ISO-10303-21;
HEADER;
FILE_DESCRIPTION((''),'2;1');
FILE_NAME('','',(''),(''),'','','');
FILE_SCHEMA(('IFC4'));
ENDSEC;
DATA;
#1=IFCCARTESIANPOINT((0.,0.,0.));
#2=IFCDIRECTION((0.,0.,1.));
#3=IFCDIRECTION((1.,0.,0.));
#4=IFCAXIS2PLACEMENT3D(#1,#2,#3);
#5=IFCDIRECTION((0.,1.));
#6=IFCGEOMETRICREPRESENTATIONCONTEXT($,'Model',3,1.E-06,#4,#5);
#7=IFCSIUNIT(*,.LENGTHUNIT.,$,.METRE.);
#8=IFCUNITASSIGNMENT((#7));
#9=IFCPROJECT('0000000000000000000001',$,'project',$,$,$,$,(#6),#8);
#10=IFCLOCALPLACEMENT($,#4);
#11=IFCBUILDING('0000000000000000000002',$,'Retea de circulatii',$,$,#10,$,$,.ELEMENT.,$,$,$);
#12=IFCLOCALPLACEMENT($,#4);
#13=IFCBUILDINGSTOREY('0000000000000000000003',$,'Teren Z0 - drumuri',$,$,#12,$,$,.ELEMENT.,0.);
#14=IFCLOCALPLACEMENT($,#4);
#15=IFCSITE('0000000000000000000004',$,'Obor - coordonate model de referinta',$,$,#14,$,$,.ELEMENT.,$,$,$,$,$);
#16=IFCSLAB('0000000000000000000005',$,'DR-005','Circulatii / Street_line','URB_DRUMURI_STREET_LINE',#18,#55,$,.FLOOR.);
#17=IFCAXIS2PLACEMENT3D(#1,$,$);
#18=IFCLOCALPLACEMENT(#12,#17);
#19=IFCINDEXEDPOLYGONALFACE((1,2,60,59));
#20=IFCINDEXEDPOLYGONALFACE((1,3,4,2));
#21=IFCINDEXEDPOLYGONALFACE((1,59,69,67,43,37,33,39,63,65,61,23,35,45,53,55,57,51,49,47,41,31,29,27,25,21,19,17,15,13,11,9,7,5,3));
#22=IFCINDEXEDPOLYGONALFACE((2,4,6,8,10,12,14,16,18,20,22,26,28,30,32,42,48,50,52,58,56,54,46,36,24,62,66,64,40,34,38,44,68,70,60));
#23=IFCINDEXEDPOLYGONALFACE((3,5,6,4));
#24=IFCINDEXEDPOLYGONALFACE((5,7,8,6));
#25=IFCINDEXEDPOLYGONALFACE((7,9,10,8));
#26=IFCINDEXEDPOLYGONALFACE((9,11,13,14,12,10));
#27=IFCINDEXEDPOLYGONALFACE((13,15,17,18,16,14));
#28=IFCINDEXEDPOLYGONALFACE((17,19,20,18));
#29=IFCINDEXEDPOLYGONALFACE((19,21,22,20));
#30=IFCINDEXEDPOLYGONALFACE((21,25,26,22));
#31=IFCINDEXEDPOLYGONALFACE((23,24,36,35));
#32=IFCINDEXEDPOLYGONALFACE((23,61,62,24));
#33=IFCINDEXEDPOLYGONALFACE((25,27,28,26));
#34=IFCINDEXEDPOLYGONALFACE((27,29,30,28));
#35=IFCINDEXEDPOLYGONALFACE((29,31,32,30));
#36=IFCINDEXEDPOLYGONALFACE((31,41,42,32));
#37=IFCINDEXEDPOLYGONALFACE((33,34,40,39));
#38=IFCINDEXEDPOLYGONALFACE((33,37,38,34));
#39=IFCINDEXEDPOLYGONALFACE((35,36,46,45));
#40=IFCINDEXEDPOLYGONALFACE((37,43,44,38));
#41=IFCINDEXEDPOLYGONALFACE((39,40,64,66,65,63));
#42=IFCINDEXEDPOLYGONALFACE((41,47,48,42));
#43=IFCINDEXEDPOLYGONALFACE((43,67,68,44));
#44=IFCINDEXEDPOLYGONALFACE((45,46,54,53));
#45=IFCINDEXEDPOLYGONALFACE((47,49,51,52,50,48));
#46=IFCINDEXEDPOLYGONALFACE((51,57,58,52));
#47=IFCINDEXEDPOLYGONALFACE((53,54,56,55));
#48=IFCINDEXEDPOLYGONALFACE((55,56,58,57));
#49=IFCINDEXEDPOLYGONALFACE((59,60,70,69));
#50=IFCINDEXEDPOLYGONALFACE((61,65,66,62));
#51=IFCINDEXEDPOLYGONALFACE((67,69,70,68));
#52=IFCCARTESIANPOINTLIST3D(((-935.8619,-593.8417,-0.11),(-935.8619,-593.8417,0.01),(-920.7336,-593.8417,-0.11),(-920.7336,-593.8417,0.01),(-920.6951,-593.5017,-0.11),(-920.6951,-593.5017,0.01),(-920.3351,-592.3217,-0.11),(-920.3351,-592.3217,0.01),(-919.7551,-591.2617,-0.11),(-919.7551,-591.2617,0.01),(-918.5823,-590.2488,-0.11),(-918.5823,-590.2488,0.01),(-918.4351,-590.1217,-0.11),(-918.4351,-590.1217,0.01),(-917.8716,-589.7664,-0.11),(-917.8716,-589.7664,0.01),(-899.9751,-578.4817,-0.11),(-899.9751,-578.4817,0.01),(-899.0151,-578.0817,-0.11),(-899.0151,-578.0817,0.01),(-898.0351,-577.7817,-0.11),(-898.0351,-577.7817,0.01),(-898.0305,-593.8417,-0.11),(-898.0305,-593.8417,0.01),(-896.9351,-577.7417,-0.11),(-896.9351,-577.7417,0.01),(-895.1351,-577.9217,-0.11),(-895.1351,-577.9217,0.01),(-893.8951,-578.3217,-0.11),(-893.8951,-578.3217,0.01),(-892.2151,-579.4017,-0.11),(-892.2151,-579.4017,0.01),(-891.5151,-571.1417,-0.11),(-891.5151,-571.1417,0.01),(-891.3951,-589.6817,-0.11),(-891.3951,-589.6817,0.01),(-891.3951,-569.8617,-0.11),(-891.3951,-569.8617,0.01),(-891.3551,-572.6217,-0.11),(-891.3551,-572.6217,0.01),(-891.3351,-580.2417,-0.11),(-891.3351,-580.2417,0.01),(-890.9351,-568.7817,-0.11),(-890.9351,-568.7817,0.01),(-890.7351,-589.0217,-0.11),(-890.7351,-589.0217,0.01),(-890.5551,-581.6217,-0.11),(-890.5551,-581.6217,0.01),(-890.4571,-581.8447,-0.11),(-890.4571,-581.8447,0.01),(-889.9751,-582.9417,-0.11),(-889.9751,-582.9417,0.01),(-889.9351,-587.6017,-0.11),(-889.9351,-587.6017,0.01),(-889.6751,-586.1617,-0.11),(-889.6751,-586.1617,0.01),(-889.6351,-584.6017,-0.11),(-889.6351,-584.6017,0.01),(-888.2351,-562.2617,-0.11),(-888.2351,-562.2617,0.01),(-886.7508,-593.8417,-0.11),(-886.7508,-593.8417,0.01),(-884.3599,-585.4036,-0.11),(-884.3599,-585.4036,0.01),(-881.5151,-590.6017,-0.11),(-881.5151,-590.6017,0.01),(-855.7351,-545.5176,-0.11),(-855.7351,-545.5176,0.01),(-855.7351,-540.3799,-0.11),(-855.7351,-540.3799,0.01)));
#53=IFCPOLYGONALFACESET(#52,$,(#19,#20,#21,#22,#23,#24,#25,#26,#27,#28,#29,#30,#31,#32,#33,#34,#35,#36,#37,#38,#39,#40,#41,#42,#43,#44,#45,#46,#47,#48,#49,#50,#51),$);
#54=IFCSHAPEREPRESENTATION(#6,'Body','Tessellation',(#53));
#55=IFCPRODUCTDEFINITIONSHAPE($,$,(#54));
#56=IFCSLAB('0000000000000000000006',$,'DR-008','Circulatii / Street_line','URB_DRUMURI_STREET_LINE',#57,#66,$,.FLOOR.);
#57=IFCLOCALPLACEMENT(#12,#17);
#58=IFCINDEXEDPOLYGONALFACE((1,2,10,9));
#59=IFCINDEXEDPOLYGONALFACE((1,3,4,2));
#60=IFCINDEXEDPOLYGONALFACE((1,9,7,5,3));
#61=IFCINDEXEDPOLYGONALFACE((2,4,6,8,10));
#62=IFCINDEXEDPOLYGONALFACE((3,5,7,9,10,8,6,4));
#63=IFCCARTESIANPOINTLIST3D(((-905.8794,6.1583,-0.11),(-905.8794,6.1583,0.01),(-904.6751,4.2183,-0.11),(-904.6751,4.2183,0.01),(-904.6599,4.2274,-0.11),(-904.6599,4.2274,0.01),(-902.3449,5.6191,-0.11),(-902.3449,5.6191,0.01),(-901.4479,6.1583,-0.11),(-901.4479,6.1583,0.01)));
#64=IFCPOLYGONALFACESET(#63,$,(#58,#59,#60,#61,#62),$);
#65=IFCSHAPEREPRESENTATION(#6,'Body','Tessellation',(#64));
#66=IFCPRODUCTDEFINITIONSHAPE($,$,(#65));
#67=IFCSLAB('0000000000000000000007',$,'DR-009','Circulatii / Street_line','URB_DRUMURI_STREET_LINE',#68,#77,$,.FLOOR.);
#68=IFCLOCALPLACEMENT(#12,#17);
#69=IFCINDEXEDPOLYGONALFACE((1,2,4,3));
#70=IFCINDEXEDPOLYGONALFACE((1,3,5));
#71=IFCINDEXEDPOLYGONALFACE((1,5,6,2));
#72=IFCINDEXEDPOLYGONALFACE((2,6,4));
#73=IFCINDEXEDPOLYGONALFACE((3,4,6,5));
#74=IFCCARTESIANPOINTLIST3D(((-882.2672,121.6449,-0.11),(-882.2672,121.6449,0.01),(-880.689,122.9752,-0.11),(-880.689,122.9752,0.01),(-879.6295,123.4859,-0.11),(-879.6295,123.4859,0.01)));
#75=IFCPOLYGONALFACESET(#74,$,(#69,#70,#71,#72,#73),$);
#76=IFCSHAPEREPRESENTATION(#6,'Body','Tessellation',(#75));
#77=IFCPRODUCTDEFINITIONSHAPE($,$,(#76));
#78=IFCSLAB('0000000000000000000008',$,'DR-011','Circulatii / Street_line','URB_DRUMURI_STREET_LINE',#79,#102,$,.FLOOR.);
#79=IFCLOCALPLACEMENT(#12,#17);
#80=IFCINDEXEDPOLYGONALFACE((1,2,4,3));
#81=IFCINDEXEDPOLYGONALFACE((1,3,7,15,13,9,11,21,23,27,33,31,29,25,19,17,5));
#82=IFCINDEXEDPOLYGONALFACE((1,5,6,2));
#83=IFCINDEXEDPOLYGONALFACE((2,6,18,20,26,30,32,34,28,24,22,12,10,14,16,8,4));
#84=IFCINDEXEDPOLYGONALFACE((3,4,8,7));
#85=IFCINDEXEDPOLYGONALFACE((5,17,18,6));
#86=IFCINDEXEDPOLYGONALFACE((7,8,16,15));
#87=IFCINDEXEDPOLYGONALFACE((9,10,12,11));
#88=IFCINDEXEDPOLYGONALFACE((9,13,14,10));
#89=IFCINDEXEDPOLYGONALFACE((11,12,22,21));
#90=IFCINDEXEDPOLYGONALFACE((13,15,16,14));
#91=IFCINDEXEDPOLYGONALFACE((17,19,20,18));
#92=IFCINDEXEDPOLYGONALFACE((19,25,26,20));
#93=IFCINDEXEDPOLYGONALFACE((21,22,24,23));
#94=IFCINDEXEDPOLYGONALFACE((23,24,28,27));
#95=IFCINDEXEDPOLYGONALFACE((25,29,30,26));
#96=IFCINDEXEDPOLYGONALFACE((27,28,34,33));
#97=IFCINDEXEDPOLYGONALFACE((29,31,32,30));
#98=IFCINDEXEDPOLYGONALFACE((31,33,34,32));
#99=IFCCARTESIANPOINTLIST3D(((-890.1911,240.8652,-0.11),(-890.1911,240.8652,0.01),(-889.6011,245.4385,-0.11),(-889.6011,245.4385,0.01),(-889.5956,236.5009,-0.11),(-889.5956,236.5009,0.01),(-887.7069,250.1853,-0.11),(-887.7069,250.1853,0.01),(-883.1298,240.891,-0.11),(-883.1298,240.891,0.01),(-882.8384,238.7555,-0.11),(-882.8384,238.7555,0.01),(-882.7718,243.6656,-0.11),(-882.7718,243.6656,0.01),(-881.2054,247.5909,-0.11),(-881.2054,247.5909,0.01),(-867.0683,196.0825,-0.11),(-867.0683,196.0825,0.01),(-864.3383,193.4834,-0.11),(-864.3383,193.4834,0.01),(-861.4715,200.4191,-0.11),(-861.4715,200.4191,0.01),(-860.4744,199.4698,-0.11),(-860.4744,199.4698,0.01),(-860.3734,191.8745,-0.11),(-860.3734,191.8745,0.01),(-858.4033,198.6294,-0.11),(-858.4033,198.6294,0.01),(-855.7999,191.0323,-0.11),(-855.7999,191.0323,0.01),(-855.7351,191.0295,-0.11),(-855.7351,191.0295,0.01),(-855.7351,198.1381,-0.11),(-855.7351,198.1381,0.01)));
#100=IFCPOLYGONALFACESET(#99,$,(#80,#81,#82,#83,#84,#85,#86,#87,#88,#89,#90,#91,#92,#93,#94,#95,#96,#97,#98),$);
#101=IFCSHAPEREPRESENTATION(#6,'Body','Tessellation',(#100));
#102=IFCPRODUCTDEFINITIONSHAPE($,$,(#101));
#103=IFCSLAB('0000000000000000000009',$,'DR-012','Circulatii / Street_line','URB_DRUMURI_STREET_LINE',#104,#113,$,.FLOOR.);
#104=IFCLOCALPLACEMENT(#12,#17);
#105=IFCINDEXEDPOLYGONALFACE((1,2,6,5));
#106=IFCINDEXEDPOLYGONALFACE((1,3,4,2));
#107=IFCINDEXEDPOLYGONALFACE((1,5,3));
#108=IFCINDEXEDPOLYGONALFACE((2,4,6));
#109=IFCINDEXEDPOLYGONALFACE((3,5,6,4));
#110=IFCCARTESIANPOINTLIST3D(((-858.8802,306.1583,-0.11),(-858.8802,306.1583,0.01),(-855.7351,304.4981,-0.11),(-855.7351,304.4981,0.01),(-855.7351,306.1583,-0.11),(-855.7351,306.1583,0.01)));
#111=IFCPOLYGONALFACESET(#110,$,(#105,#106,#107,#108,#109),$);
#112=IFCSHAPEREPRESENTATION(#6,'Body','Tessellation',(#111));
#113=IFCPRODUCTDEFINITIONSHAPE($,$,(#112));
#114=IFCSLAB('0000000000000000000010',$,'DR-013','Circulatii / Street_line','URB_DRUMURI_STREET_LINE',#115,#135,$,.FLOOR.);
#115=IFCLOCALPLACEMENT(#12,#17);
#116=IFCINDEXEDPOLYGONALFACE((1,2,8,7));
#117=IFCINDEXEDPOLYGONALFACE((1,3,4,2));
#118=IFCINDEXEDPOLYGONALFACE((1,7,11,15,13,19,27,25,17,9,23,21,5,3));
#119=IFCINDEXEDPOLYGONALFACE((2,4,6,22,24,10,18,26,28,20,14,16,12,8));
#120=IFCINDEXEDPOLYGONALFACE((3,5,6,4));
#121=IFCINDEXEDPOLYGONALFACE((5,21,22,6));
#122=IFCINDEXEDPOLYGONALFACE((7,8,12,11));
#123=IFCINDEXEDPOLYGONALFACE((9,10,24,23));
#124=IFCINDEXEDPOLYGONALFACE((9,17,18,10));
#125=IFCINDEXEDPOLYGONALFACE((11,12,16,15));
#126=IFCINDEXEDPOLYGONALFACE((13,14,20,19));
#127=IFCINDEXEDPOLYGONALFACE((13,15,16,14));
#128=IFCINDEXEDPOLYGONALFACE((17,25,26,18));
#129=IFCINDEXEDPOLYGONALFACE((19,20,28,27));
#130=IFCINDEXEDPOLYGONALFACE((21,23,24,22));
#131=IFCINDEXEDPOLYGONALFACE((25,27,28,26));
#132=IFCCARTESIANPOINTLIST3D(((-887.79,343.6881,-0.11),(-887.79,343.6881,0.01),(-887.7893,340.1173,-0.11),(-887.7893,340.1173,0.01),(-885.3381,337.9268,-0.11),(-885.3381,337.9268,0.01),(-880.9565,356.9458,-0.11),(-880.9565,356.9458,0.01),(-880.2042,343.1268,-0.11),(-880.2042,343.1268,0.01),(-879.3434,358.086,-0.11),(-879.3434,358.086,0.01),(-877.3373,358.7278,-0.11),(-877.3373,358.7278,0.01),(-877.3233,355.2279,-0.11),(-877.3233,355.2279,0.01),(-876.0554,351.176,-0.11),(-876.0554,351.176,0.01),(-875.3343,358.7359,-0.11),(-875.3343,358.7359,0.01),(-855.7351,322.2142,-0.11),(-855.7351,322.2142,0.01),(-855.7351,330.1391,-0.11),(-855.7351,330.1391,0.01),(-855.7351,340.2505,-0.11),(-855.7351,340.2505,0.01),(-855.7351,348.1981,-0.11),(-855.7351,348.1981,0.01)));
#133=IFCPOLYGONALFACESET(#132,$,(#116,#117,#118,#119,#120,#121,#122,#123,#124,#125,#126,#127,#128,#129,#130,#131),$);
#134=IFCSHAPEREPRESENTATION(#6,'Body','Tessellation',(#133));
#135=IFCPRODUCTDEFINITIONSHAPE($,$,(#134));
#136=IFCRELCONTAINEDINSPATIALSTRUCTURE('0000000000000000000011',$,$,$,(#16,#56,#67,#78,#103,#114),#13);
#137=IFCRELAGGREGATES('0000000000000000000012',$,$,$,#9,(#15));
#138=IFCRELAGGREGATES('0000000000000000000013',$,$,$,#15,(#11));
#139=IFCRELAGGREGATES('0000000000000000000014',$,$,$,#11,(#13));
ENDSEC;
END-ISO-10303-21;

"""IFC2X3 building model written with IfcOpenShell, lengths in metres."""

from ifc_helpers import new_model, si_unit, direction, frame, origin_with_axes, place, context, project, spatial, polyline, outline, extrude, element, save


model = new_model("IFC2X3")

# Units and contexts
model_context = context("Model", 3, precision=1e-06, world=origin_with_axes(), true_north=direction((0.0, 1.0)))
ifc_project = project(units=[si_unit("LENGTHUNIT", "METRE")], contexts=[model_context])

# Site, building, storey
site_placement = place(None, origin_with_axes())
site = spatial("IfcSite", under=ifc_project, at=site_placement, Name="Obor - coordonate model de referinta", CompositionType="ELEMENT")
building_placement = place(None, origin_with_axes())
building = spatial("IfcBuilding", under=site, at=building_placement, Name="Retea de circulatii", CompositionType="ELEMENT")
storey_placement = place(None, origin_with_axes())
storey = spatial("IfcBuildingStorey", under=building, at=storey_placement, Name="Teren Z0 - drumuri", CompositionType="ELEMENT", Elevation=0.0)

# Slabs
slab_1_placement = place(None, origin_with_axes())
element("IfcSlab", 1, at=slab_1_placement, inside=storey, Name="DR-005", Description="Circulatii / Street_line", ObjectType="URB_DRUMURI_STREET_LINE", PredefinedType="FLOOR", context=model_context, shape_type="SweptSolid", body=[
    extrude(outline(polyline([(-891.3951, -569.8617), (-890.9351, -568.7817), (-855.7351, -545.5176), (-855.7351, -540.3799), (-888.2351, -562.2617), (-935.8619, -593.8417), (-920.7336, -593.8417), (-920.6951, -593.5017), (-920.3351, -592.3217), (-919.7551, -591.2617), (-918.5823, -590.2488), (-918.4351, -590.1217), (-917.8716, -589.7664), (-899.9751, -578.4817), (-899.0151, -578.0817), (-898.0351, -577.7817), (-896.9351, -577.7417), (-895.1351, -577.9217), (-893.8951, -578.3217), (-892.2151, -579.4017), (-891.3351, -580.2417), (-890.5551, -581.6217), (-890.4571, -581.8447), (-889.9751, -582.9417), (-889.6351, -584.6017), (-889.6751, -586.1617), (-889.9351, -587.6017), (-890.7351, -589.0217), (-891.3951, -589.6817), (-898.0305, -593.8417), (-886.7508, -593.8417), (-881.5151, -590.6017), (-884.3599, -585.4036), (-891.3551, -572.6217), (-891.5151, -571.1417), (-891.3951, -569.8617)])), frame((0.0, 0.0, -0.11), z_axis=(0.0, 0.0, 1.0), x_axis=(1.0, 0.0, 0.0)), (0.0, 0.0, 1.0), 0.12),
])
slab_2_placement = place(None, origin_with_axes())
element("IfcSlab", 2, at=slab_2_placement, inside=storey, Name="DR-008", Description="Circulatii / Street_line", ObjectType="URB_DRUMURI_STREET_LINE", PredefinedType="FLOOR", context=model_context, shape_type="SweptSolid", body=[
    extrude(outline(polyline([(-904.6599, 4.2274), (-902.3449, 5.6191), (-901.4479, 6.1583), (-905.8794, 6.1583), (-904.6751, 4.2183), (-904.6599, 4.2274)])), frame((0.0, 0.0, -0.11), z_axis=(0.0, 0.0, 1.0), x_axis=(1.0, 0.0, 0.0)), (0.0, 0.0, 1.0), 0.12),
])
slab_3_placement = place(None, origin_with_axes())
element("IfcSlab", 3, at=slab_3_placement, inside=storey, Name="DR-009", Description="Circulatii / Street_line", ObjectType="URB_DRUMURI_STREET_LINE", PredefinedType="FLOOR", context=model_context, shape_type="SweptSolid", body=[
    extrude(outline(polyline([(-882.2672, 121.6449), (-879.6295, 123.4859), (-880.689, 122.9752), (-882.2672, 121.6449)])), frame((0.0, 0.0, -0.11), z_axis=(0.0, 0.0, 1.0), x_axis=(1.0, 0.0, 0.0)), (0.0, 0.0, 1.0), 0.12),
])
slab_4_placement = place(None, origin_with_axes())
element("IfcSlab", 4, at=slab_4_placement, inside=storey, Name="DR-011", Description="Circulatii / Street_line", ObjectType="URB_DRUMURI_STREET_LINE", PredefinedType="FLOOR", context=model_context, shape_type="SweptSolid", body=[
    extrude(outline(polyline([(-864.3383, 193.4834), (-860.3734, 191.8745), (-855.7999, 191.0323), (-855.7351, 191.0295), (-855.7351, 198.1381), (-858.4033, 198.6294), (-860.4744, 199.4698), (-861.4715, 200.4191), (-882.8384, 238.7555), (-883.1298, 240.891), (-882.7718, 243.6656), (-881.2054, 247.5909), (-887.7069, 250.1853), (-889.6011, 245.4385), (-890.1911, 240.8652), (-889.5956, 236.5009), (-867.0683, 196.0825), (-864.3383, 193.4834)])), frame((0.0, 0.0, -0.11), z_axis=(0.0, 0.0, 1.0), x_axis=(1.0, 0.0, 0.0)), (0.0, 0.0, 1.0), 0.12),
])
slab_5_placement = place(None, origin_with_axes())
element("IfcSlab", 5, at=slab_5_placement, inside=storey, Name="DR-012", Description="Circulatii / Street_line", ObjectType="URB_DRUMURI_STREET_LINE", PredefinedType="FLOOR", context=model_context, shape_type="SweptSolid", body=[
    extrude(outline(polyline([(-855.7351, 304.4981), (-855.7351, 306.1583), (-858.8802, 306.1583), (-855.7351, 304.4981)])), frame((0.0, 0.0, -0.11), z_axis=(0.0, 0.0, 1.0), x_axis=(1.0, 0.0, 0.0)), (0.0, 0.0, 1.0), 0.12),
])
slab_6_placement = place(None, origin_with_axes())
element("IfcSlab", 6, at=slab_6_placement, inside=storey, Name="DR-013", Description="Circulatii / Street_line", ObjectType="URB_DRUMURI_STREET_LINE", PredefinedType="FLOOR", context=model_context, shape_type="SweptSolid", body=[
    extrude(outline(polyline([(-887.7893, 340.1173), (-885.3381, 337.9268), (-855.7351, 322.2142), (-855.7351, 330.1391), (-880.2042, 343.1268), (-876.0554, 351.176), (-855.7351, 340.2505), (-855.7351, 348.1981), (-875.3343, 358.7359), (-877.3373, 358.7278), (-877.3233, 355.2279), (-879.3434, 358.086), (-880.9565, 356.9458), (-887.79, 343.6881), (-887.7893, 340.1173)])), frame((0.0, 0.0, -0.11), z_axis=(0.0, 0.0, 1.0), x_axis=(1.0, 0.0, 0.0)), (0.0, 0.0, 1.0), 0.12),
])

save(model, "model.ifc")
